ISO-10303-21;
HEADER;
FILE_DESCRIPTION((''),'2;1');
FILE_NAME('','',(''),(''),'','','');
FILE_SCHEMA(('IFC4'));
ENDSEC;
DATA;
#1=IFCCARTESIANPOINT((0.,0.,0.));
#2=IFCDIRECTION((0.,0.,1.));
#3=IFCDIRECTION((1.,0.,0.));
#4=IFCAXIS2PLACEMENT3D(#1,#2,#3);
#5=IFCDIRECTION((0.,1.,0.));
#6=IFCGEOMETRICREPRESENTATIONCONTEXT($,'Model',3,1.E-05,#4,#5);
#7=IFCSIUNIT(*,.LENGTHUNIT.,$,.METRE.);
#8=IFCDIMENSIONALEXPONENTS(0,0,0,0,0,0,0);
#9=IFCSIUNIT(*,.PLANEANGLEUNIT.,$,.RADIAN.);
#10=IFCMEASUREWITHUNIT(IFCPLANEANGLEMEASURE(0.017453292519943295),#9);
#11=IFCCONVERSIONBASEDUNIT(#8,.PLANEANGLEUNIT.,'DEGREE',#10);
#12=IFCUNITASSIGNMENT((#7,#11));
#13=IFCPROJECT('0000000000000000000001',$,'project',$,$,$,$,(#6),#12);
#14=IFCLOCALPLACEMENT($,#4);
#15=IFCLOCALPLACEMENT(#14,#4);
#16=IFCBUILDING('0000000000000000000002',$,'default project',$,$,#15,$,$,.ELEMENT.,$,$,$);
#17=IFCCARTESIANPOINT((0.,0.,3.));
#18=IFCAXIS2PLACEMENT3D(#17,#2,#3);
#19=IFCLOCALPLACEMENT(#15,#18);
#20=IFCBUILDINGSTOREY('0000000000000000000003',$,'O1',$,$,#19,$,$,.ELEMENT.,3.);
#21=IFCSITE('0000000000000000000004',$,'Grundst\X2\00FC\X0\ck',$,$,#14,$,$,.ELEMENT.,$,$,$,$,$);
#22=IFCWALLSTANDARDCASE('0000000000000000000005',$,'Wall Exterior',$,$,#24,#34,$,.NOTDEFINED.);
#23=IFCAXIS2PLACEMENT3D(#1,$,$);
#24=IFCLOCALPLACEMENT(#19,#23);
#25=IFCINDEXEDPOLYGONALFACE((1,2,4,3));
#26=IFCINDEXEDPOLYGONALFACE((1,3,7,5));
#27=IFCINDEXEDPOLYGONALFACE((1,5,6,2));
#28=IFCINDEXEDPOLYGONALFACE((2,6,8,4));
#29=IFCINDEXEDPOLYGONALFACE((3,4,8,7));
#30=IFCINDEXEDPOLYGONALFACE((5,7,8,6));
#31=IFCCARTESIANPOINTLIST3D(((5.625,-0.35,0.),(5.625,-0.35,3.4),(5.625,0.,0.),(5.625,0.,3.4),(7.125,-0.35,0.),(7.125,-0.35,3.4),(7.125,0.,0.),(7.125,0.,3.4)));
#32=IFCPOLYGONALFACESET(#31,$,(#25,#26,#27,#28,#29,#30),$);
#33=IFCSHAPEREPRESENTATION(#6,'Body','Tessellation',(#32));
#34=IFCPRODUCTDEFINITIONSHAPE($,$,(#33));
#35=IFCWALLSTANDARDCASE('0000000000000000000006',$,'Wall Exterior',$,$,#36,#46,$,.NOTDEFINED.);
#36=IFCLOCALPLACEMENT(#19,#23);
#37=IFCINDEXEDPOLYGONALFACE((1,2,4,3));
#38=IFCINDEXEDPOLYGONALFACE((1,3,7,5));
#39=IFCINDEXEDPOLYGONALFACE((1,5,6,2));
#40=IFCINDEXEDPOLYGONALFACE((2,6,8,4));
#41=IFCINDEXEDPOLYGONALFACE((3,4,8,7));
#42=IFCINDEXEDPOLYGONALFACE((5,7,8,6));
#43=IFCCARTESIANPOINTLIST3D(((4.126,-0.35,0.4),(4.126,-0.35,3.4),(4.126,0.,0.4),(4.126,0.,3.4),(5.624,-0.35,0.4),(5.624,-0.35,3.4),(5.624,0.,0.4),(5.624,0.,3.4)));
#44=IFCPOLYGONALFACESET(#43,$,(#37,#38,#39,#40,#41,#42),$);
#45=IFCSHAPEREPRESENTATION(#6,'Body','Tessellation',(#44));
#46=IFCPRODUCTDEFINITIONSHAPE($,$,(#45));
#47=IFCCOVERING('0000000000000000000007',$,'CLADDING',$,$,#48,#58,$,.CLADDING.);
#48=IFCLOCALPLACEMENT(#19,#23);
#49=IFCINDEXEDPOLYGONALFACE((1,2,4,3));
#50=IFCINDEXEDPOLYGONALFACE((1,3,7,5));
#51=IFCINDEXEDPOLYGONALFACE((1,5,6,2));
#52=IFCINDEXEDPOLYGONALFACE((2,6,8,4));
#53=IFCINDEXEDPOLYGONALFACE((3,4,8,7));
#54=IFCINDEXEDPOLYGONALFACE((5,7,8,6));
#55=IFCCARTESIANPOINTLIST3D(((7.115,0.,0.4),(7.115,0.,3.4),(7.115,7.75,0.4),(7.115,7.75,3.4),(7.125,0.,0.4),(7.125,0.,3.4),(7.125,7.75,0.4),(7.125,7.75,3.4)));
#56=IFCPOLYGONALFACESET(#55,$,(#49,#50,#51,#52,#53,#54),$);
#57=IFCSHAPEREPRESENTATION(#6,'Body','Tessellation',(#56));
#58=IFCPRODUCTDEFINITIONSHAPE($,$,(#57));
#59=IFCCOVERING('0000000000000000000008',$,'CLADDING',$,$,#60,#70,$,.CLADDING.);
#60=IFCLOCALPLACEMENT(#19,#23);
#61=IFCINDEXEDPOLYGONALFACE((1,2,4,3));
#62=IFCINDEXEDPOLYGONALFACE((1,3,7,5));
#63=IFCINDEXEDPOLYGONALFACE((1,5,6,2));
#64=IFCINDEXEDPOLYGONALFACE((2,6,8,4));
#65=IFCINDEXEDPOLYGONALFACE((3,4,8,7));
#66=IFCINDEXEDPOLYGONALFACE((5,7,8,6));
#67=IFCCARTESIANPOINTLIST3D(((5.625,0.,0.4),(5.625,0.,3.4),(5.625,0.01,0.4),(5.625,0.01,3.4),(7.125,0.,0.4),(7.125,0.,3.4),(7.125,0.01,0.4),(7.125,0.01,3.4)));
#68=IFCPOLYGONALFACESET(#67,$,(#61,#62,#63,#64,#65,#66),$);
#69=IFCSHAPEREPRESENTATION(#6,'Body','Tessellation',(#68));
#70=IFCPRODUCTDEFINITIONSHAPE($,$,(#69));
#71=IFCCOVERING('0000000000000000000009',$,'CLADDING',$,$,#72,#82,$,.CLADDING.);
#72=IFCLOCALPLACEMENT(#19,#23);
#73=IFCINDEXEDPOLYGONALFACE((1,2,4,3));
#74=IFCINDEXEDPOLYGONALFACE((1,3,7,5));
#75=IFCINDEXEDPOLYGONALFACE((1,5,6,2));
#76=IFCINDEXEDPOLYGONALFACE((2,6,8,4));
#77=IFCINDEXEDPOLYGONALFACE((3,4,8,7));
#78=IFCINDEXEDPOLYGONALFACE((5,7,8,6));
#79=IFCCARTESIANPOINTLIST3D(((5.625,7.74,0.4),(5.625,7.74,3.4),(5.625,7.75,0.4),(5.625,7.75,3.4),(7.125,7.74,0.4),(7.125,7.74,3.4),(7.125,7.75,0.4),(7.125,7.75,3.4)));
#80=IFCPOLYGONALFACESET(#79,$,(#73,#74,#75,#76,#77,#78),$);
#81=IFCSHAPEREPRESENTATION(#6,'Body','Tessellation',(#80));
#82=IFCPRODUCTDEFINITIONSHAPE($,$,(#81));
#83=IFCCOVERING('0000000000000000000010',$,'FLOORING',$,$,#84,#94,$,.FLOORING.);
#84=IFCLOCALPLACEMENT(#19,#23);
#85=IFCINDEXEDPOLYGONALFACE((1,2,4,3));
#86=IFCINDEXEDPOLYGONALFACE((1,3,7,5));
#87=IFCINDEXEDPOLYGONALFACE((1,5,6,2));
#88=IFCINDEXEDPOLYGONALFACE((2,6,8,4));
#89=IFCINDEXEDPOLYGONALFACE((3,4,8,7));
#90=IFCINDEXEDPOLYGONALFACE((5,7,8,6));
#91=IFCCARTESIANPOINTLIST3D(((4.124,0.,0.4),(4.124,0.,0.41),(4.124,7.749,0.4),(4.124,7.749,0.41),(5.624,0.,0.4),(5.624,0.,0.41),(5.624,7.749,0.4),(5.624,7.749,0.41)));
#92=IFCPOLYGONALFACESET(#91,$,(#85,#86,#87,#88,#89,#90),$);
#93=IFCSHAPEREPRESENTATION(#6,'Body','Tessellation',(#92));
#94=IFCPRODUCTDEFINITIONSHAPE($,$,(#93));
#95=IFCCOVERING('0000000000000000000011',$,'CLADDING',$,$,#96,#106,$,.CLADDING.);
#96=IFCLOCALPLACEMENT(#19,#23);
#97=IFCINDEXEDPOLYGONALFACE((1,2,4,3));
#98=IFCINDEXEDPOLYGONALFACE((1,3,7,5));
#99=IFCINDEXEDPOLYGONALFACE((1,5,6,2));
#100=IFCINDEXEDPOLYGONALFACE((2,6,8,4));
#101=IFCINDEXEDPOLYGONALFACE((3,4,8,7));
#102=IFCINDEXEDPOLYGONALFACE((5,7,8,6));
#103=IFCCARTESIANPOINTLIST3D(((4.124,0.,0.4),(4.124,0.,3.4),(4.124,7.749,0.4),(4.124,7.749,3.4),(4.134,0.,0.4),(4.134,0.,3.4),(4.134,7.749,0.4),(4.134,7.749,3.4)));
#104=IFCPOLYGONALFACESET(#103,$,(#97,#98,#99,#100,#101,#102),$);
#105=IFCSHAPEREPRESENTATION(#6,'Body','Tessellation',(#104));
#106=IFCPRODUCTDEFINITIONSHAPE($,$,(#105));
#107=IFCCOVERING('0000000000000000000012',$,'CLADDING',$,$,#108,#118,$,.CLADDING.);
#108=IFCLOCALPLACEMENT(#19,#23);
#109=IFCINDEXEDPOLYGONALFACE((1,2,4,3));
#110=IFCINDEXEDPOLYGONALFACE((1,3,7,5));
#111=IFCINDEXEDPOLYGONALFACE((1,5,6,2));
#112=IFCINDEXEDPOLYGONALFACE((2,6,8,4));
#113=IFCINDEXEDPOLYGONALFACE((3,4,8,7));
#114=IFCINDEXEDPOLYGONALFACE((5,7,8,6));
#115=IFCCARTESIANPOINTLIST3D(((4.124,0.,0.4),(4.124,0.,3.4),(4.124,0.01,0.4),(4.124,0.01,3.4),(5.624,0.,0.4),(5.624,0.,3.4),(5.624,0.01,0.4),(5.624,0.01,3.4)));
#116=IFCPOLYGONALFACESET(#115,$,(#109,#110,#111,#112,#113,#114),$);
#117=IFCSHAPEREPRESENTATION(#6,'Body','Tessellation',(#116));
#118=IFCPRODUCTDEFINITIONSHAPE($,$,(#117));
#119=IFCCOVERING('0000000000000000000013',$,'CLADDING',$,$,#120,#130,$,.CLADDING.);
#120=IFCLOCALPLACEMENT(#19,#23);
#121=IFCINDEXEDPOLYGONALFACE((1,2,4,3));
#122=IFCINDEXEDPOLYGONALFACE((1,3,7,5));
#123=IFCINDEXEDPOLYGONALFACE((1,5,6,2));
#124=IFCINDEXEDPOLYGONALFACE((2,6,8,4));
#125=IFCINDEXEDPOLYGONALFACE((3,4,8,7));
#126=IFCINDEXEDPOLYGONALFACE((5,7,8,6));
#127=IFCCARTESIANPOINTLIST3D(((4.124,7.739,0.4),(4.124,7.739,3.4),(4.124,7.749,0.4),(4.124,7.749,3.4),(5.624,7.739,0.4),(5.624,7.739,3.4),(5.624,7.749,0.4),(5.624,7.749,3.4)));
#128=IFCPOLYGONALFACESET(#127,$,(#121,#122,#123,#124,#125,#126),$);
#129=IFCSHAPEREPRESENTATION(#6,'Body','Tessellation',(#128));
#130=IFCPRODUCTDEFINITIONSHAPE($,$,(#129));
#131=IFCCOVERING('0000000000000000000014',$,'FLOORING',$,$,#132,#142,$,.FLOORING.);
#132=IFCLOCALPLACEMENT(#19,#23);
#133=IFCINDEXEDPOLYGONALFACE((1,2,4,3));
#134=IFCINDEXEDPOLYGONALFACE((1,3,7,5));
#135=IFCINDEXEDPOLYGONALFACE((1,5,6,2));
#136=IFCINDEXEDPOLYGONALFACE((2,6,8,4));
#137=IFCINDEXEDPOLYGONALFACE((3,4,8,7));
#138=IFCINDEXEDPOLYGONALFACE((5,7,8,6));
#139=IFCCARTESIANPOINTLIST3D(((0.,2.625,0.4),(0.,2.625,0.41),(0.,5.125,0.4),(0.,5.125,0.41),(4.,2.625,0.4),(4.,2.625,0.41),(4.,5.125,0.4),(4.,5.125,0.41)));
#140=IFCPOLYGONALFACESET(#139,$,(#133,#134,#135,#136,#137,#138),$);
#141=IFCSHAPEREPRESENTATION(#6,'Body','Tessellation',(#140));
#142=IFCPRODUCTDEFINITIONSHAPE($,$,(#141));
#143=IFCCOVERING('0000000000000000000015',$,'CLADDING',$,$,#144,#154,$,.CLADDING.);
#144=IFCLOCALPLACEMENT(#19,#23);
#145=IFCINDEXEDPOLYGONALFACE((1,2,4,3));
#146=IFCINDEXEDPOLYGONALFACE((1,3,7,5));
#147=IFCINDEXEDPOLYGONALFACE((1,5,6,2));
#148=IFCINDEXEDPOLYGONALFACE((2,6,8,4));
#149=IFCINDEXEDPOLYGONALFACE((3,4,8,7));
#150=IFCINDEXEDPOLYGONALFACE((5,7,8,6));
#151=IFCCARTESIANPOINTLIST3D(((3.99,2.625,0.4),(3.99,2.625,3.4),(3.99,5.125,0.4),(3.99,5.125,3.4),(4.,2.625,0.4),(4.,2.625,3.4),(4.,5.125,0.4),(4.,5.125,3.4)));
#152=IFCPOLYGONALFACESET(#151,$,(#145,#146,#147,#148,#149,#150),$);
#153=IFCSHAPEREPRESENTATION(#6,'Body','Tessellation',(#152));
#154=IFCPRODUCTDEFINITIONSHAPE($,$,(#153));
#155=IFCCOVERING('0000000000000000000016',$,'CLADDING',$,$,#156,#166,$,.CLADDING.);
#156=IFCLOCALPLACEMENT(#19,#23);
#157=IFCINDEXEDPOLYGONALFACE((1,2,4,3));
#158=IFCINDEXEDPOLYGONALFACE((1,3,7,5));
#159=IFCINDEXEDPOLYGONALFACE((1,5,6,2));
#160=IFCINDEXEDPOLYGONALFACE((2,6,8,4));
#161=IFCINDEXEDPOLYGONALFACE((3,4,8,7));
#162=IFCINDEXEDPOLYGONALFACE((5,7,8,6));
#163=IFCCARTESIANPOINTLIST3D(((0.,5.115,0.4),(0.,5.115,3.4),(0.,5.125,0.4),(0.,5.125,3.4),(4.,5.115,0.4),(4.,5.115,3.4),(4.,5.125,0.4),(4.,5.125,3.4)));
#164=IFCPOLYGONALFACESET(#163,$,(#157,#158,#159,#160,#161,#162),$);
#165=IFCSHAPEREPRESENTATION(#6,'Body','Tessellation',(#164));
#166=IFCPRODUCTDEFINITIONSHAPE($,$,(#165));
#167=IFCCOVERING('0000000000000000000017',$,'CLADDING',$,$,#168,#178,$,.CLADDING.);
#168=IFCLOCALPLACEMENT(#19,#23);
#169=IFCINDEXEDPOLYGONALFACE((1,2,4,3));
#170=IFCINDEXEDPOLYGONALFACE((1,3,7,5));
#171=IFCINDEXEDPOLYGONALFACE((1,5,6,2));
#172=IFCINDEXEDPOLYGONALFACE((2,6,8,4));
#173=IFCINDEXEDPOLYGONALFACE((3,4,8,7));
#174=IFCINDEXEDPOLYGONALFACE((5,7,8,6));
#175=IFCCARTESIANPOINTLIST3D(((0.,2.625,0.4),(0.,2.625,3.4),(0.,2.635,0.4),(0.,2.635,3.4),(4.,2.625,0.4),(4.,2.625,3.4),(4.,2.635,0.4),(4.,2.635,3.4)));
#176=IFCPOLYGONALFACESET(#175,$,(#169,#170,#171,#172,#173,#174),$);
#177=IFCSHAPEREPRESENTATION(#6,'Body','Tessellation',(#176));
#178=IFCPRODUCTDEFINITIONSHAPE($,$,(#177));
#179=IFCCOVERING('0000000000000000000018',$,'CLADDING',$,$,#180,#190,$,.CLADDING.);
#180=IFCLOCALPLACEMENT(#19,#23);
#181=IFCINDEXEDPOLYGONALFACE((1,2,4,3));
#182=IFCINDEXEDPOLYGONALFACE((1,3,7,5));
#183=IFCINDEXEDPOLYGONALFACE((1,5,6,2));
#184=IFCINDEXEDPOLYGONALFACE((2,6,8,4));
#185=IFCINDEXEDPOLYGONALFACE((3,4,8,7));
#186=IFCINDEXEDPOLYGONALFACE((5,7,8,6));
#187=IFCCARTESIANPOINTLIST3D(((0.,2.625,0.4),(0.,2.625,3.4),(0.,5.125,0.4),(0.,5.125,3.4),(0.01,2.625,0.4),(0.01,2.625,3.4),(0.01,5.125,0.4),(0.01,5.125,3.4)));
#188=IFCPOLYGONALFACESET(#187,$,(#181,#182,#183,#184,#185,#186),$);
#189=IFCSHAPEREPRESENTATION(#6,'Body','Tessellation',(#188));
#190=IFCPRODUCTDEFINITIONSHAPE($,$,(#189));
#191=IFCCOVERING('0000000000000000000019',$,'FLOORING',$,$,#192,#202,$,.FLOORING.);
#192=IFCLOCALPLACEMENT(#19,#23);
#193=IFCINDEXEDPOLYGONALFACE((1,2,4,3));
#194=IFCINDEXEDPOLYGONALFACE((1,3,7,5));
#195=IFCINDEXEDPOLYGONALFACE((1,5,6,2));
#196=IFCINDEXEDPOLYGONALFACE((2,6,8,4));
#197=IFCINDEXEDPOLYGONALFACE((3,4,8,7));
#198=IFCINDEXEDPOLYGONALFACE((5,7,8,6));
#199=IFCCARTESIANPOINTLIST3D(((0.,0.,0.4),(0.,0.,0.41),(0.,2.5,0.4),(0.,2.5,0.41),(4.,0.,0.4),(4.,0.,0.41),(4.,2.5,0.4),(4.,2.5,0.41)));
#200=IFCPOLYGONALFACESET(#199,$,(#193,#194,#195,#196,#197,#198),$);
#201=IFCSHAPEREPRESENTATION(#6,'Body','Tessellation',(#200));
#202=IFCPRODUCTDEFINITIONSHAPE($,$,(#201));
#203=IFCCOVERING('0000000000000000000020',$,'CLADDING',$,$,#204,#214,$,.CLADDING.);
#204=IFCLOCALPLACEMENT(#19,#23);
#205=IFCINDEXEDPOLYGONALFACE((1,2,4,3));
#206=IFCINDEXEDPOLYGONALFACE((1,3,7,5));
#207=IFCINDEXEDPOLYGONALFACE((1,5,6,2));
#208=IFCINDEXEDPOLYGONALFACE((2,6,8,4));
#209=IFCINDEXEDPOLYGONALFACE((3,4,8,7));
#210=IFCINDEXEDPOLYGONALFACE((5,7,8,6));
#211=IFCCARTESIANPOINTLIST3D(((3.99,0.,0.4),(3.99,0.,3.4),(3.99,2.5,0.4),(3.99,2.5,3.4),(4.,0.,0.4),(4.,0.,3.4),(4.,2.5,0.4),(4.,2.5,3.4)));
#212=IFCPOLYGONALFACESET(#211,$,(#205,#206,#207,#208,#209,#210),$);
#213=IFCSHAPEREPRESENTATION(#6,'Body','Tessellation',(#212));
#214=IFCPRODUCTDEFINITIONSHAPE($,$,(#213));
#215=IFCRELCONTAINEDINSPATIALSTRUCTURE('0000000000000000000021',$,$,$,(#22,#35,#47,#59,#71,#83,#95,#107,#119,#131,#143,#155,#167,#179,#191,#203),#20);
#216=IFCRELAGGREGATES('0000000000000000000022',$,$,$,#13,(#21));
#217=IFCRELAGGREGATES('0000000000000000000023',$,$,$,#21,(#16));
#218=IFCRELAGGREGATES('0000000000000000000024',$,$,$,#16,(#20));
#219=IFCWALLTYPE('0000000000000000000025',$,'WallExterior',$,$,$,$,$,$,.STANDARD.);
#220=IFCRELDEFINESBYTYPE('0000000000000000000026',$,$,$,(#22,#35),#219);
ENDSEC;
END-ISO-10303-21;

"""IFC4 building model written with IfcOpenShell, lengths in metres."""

from ifc_helpers import new_model, entity, si_unit, converted_unit, direction, frame, origin_with_axes, place, context, project, spatial, polyline, outline, extrude, type_object, element, save


model = new_model("IFC4")

# Units and contexts
model_context = context("Model", 3, precision=1e-05, world=origin_with_axes(), true_north=direction((0.0, 1.0, 0.0)))
ifc_project = project(units=[si_unit("LENGTHUNIT", "METRE"), converted_unit("PLANEANGLEUNIT", "DEGREE", entity("IfcPlaneAngleMeasure", 0.017453292519943295), si_unit("PLANEANGLEUNIT", "RADIAN"), dimensions=[0, 0, 0, 0, 0, 0, 0])], contexts=[model_context])

# Site, building, storey
site_placement = place(None, origin_with_axes())
site = spatial("IfcSite", under=ifc_project, at=site_placement, Name="Grundstück", CompositionType="ELEMENT")
building_placement = place(site_placement, origin_with_axes())
building = spatial("IfcBuilding", under=site, at=building_placement, Name="default project", CompositionType="ELEMENT")
placement_1 = place(building_placement, frame((0.0, 0.0, 3.0), z_axis=(0.0, 0.0, 1.0), x_axis=(1.0, 0.0, 0.0)))
storey = spatial("IfcBuildingStorey", under=building, at=placement_1, Name="O1", CompositionType="ELEMENT", Elevation=3.0)

# Walls
wall_type_1 = type_object("IfcWallType", Name="WallExterior", PredefinedType="STANDARD")
placement_2 = place(placement_1, frame((7.3, -0.175, 0.0), z_axis=(0.0, 0.0, 1.0), x_axis=(-1.0, 0.0, 0.0)))
element("IfcWallStandardCase", 1, at=placement_2, inside=storey, type_object=wall_type_1, Name="Wall Exterior", PredefinedType="NOTDEFINED", context=model_context, shape_type="SweptSolid", body=[
    extrude(outline(polyline([(0.175, -0.175), (1.675, -0.175), (1.675, 0.175), (0.175, 0.175), (0.175, -0.175)])), origin_with_axes(), (0.0, 0.0, 1.0), 3.4),
])
placement_3 = place(placement_1, frame((5.624, -0.175, 0.4), z_axis=(0.0, 0.0, 1.0), x_axis=(-1.0, 0.0, 0.0)))
element("IfcWallStandardCase", 2, at=placement_3, inside=storey, type_object=wall_type_1, Name="Wall Exterior", PredefinedType="NOTDEFINED", context=model_context, shape_type="SweptSolid", body=[
    extrude(outline(polyline([(0.0, -0.175), (1.498, -0.175), (1.498, 0.175), (0.0, 0.175), (0.0, -0.175)])), origin_with_axes(), (0.0, 0.0, 1.0), 3.0),
])

# Coverings
element("IfcCovering", 3, at=placement_1, inside=storey, Name="CLADDING", PredefinedType="CLADDING", context=model_context, shape_type="SweptSolid", body=[
    extrude(outline(polyline([(7.115, 7.75), (7.115, 0.0), (7.125, 0.0), (7.125, 7.75), (7.115, 7.75)])), frame((0.0, 0.0, 0.4), z_axis=(0.0, 0.0, 1.0), x_axis=(1.0, 0.0, 0.0)), (0.0, 0.0, 1.0), 3.0),
])
element("IfcCovering", 4, at=placement_1, inside=storey, Name="CLADDING", PredefinedType="CLADDING", context=model_context, shape_type="SweptSolid", body=[
    extrude(outline(polyline([(7.125, 0.01), (5.625, 0.01), (5.625, 0.0), (7.125, 0.0), (7.125, 0.01)])), frame((0.0, 0.0, 0.4), z_axis=(0.0, 0.0, 1.0), x_axis=(1.0, 0.0, 0.0)), (0.0, 0.0, 1.0), 3.0),
])
element("IfcCovering", 5, at=placement_1, inside=storey, Name="CLADDING", PredefinedType="CLADDING", context=model_context, shape_type="SweptSolid", body=[
    extrude(outline(polyline([(5.625, 7.74), (7.125, 7.74), (7.125, 7.75), (5.625, 7.75), (5.625, 7.74)])), frame((0.0, 0.0, 0.4), z_axis=(0.0, 0.0, 1.0), x_axis=(1.0, 0.0, 0.0)), (0.0, 0.0, 1.0), 3.0),
])
element("IfcCovering", 6, at=placement_1, inside=storey, Name="FLOORING", PredefinedType="FLOORING", context=model_context, shape_type="SweptSolid", body=[
    extrude(outline(polyline([(5.624, 7.749), (4.124, 7.749), (4.124, 0.0), (5.624, 0.0), (5.624, 7.749)])), frame((0.0, 0.0, 0.4), z_axis=(0.0, 0.0, 1.0), x_axis=(1.0, 0.0, 0.0)), (0.0, 0.0, 1.0), 0.01),
])
element("IfcCovering", 7, at=placement_1, inside=storey, Name="CLADDING", PredefinedType="CLADDING", context=model_context, shape_type="SweptSolid", body=[
    extrude(outline(polyline([(4.134, 0.0), (4.134, 7.749), (4.124, 7.749), (4.124, 0.0), (4.134, 0.0)])), frame((0.0, 0.0, 0.4), z_axis=(0.0, 0.0, 1.0), x_axis=(1.0, 0.0, 0.0)), (0.0, 0.0, 1.0), 3.0),
])
element("IfcCovering", 8, at=placement_1, inside=storey, Name="CLADDING", PredefinedType="CLADDING", context=model_context, shape_type="SweptSolid", body=[
    extrude(outline(polyline([(5.624, 0.01), (4.124, 0.01), (4.124, 0.0), (5.624, 0.0), (5.624, 0.01)])), frame((0.0, 0.0, 0.4), z_axis=(0.0, 0.0, 1.0), x_axis=(1.0, 0.0, 0.0)), (0.0, 0.0, 1.0), 3.0),
])
element("IfcCovering", 9, at=placement_1, inside=storey, Name="CLADDING", PredefinedType="CLADDING", context=model_context, shape_type="SweptSolid", body=[
    extrude(outline(polyline([(4.124, 7.739), (5.624, 7.739), (5.624, 7.749), (4.124, 7.749), (4.124, 7.739)])), frame((0.0, 0.0, 0.4), z_axis=(0.0, 0.0, 1.0), x_axis=(1.0, 0.0, 0.0)), (0.0, 0.0, 1.0), 3.0),
])
element("IfcCovering", 10, at=placement_1, inside=storey, Name="FLOORING", PredefinedType="FLOORING", context=model_context, shape_type="SweptSolid", body=[
    extrude(outline(polyline([(4.0, 5.125), (0.0, 5.125), (0.0, 2.625), (4.0, 2.625), (4.0, 5.125)])), frame((0.0, 0.0, 0.4), z_axis=(0.0, 0.0, 1.0), x_axis=(1.0, 0.0, 0.0)), (0.0, 0.0, 1.0), 0.01),
])
element("IfcCovering", 11, at=placement_1, inside=storey, Name="CLADDING", PredefinedType="CLADDING", context=model_context, shape_type="SweptSolid", body=[
    extrude(outline(polyline([(3.99, 5.125), (3.99, 2.625), (4.0, 2.625), (4.0, 5.125), (3.99, 5.125)])), frame((0.0, 0.0, 0.4), z_axis=(0.0, 0.0, 1.0), x_axis=(1.0, 0.0, 0.0)), (0.0, 0.0, 1.0), 3.0),
])
element("IfcCovering", 12, at=placement_1, inside=storey, Name="CLADDING", PredefinedType="CLADDING", context=model_context, shape_type="SweptSolid", body=[
    extrude(outline(polyline([(0.0, 5.115), (4.0, 5.115), (4.0, 5.125), (0.0, 5.125), (0.0, 5.115)])), frame((0.0, 0.0, 0.4), z_axis=(0.0, 0.0, 1.0), x_axis=(1.0, 0.0, 0.0)), (0.0, 0.0, 1.0), 3.0),
])
element("IfcCovering", 13, at=placement_1, inside=storey, Name="CLADDING", PredefinedType="CLADDING", context=model_context, shape_type="SweptSolid", body=[
    extrude(outline(polyline([(4.0, 2.635), (0.0, 2.635), (0.0, 2.625), (4.0, 2.625), (4.0, 2.635)])), frame((0.0, 0.0, 0.4), z_axis=(0.0, 0.0, 1.0), x_axis=(1.0, 0.0, 0.0)), (0.0, 0.0, 1.0), 3.0),
])
element("IfcCovering", 14, at=placement_1, inside=storey, Name="CLADDING", PredefinedType="CLADDING", context=model_context, shape_type="SweptSolid", body=[
    extrude(outline(polyline([(0.01, 2.625), (0.01, 5.125), (0.0, 5.125), (0.0, 2.625), (0.01, 2.625)])), frame((0.0, 0.0, 0.4), z_axis=(0.0, 0.0, 1.0), x_axis=(1.0, 0.0, 0.0)), (0.0, 0.0, 1.0), 3.0),
])
element("IfcCovering", 15, at=placement_1, inside=storey, Name="FLOORING", PredefinedType="FLOORING", context=model_context, shape_type="SweptSolid", body=[
    extrude(outline(polyline([(4.0, 2.5), (0.0, 2.5), (0.0, 0.0), (4.0, 0.0), (4.0, 2.5)])), frame((0.0, 0.0, 0.4), z_axis=(0.0, 0.0, 1.0), x_axis=(1.0, 0.0, 0.0)), (0.0, 0.0, 1.0), 0.01),
])
element("IfcCovering", 16, at=placement_1, inside=storey, Name="CLADDING", PredefinedType="CLADDING", context=model_context, shape_type="SweptSolid", body=[
    extrude(outline(polyline([(3.99, 2.5), (3.99, 0.0), (4.0, 0.0), (4.0, 2.5), (3.99, 2.5)])), frame((0.0, 0.0, 0.4), z_axis=(0.0, 0.0, 1.0), x_axis=(1.0, 0.0, 0.0)), (0.0, 0.0, 1.0), 3.0),
])

save(model, "model.ifc")
